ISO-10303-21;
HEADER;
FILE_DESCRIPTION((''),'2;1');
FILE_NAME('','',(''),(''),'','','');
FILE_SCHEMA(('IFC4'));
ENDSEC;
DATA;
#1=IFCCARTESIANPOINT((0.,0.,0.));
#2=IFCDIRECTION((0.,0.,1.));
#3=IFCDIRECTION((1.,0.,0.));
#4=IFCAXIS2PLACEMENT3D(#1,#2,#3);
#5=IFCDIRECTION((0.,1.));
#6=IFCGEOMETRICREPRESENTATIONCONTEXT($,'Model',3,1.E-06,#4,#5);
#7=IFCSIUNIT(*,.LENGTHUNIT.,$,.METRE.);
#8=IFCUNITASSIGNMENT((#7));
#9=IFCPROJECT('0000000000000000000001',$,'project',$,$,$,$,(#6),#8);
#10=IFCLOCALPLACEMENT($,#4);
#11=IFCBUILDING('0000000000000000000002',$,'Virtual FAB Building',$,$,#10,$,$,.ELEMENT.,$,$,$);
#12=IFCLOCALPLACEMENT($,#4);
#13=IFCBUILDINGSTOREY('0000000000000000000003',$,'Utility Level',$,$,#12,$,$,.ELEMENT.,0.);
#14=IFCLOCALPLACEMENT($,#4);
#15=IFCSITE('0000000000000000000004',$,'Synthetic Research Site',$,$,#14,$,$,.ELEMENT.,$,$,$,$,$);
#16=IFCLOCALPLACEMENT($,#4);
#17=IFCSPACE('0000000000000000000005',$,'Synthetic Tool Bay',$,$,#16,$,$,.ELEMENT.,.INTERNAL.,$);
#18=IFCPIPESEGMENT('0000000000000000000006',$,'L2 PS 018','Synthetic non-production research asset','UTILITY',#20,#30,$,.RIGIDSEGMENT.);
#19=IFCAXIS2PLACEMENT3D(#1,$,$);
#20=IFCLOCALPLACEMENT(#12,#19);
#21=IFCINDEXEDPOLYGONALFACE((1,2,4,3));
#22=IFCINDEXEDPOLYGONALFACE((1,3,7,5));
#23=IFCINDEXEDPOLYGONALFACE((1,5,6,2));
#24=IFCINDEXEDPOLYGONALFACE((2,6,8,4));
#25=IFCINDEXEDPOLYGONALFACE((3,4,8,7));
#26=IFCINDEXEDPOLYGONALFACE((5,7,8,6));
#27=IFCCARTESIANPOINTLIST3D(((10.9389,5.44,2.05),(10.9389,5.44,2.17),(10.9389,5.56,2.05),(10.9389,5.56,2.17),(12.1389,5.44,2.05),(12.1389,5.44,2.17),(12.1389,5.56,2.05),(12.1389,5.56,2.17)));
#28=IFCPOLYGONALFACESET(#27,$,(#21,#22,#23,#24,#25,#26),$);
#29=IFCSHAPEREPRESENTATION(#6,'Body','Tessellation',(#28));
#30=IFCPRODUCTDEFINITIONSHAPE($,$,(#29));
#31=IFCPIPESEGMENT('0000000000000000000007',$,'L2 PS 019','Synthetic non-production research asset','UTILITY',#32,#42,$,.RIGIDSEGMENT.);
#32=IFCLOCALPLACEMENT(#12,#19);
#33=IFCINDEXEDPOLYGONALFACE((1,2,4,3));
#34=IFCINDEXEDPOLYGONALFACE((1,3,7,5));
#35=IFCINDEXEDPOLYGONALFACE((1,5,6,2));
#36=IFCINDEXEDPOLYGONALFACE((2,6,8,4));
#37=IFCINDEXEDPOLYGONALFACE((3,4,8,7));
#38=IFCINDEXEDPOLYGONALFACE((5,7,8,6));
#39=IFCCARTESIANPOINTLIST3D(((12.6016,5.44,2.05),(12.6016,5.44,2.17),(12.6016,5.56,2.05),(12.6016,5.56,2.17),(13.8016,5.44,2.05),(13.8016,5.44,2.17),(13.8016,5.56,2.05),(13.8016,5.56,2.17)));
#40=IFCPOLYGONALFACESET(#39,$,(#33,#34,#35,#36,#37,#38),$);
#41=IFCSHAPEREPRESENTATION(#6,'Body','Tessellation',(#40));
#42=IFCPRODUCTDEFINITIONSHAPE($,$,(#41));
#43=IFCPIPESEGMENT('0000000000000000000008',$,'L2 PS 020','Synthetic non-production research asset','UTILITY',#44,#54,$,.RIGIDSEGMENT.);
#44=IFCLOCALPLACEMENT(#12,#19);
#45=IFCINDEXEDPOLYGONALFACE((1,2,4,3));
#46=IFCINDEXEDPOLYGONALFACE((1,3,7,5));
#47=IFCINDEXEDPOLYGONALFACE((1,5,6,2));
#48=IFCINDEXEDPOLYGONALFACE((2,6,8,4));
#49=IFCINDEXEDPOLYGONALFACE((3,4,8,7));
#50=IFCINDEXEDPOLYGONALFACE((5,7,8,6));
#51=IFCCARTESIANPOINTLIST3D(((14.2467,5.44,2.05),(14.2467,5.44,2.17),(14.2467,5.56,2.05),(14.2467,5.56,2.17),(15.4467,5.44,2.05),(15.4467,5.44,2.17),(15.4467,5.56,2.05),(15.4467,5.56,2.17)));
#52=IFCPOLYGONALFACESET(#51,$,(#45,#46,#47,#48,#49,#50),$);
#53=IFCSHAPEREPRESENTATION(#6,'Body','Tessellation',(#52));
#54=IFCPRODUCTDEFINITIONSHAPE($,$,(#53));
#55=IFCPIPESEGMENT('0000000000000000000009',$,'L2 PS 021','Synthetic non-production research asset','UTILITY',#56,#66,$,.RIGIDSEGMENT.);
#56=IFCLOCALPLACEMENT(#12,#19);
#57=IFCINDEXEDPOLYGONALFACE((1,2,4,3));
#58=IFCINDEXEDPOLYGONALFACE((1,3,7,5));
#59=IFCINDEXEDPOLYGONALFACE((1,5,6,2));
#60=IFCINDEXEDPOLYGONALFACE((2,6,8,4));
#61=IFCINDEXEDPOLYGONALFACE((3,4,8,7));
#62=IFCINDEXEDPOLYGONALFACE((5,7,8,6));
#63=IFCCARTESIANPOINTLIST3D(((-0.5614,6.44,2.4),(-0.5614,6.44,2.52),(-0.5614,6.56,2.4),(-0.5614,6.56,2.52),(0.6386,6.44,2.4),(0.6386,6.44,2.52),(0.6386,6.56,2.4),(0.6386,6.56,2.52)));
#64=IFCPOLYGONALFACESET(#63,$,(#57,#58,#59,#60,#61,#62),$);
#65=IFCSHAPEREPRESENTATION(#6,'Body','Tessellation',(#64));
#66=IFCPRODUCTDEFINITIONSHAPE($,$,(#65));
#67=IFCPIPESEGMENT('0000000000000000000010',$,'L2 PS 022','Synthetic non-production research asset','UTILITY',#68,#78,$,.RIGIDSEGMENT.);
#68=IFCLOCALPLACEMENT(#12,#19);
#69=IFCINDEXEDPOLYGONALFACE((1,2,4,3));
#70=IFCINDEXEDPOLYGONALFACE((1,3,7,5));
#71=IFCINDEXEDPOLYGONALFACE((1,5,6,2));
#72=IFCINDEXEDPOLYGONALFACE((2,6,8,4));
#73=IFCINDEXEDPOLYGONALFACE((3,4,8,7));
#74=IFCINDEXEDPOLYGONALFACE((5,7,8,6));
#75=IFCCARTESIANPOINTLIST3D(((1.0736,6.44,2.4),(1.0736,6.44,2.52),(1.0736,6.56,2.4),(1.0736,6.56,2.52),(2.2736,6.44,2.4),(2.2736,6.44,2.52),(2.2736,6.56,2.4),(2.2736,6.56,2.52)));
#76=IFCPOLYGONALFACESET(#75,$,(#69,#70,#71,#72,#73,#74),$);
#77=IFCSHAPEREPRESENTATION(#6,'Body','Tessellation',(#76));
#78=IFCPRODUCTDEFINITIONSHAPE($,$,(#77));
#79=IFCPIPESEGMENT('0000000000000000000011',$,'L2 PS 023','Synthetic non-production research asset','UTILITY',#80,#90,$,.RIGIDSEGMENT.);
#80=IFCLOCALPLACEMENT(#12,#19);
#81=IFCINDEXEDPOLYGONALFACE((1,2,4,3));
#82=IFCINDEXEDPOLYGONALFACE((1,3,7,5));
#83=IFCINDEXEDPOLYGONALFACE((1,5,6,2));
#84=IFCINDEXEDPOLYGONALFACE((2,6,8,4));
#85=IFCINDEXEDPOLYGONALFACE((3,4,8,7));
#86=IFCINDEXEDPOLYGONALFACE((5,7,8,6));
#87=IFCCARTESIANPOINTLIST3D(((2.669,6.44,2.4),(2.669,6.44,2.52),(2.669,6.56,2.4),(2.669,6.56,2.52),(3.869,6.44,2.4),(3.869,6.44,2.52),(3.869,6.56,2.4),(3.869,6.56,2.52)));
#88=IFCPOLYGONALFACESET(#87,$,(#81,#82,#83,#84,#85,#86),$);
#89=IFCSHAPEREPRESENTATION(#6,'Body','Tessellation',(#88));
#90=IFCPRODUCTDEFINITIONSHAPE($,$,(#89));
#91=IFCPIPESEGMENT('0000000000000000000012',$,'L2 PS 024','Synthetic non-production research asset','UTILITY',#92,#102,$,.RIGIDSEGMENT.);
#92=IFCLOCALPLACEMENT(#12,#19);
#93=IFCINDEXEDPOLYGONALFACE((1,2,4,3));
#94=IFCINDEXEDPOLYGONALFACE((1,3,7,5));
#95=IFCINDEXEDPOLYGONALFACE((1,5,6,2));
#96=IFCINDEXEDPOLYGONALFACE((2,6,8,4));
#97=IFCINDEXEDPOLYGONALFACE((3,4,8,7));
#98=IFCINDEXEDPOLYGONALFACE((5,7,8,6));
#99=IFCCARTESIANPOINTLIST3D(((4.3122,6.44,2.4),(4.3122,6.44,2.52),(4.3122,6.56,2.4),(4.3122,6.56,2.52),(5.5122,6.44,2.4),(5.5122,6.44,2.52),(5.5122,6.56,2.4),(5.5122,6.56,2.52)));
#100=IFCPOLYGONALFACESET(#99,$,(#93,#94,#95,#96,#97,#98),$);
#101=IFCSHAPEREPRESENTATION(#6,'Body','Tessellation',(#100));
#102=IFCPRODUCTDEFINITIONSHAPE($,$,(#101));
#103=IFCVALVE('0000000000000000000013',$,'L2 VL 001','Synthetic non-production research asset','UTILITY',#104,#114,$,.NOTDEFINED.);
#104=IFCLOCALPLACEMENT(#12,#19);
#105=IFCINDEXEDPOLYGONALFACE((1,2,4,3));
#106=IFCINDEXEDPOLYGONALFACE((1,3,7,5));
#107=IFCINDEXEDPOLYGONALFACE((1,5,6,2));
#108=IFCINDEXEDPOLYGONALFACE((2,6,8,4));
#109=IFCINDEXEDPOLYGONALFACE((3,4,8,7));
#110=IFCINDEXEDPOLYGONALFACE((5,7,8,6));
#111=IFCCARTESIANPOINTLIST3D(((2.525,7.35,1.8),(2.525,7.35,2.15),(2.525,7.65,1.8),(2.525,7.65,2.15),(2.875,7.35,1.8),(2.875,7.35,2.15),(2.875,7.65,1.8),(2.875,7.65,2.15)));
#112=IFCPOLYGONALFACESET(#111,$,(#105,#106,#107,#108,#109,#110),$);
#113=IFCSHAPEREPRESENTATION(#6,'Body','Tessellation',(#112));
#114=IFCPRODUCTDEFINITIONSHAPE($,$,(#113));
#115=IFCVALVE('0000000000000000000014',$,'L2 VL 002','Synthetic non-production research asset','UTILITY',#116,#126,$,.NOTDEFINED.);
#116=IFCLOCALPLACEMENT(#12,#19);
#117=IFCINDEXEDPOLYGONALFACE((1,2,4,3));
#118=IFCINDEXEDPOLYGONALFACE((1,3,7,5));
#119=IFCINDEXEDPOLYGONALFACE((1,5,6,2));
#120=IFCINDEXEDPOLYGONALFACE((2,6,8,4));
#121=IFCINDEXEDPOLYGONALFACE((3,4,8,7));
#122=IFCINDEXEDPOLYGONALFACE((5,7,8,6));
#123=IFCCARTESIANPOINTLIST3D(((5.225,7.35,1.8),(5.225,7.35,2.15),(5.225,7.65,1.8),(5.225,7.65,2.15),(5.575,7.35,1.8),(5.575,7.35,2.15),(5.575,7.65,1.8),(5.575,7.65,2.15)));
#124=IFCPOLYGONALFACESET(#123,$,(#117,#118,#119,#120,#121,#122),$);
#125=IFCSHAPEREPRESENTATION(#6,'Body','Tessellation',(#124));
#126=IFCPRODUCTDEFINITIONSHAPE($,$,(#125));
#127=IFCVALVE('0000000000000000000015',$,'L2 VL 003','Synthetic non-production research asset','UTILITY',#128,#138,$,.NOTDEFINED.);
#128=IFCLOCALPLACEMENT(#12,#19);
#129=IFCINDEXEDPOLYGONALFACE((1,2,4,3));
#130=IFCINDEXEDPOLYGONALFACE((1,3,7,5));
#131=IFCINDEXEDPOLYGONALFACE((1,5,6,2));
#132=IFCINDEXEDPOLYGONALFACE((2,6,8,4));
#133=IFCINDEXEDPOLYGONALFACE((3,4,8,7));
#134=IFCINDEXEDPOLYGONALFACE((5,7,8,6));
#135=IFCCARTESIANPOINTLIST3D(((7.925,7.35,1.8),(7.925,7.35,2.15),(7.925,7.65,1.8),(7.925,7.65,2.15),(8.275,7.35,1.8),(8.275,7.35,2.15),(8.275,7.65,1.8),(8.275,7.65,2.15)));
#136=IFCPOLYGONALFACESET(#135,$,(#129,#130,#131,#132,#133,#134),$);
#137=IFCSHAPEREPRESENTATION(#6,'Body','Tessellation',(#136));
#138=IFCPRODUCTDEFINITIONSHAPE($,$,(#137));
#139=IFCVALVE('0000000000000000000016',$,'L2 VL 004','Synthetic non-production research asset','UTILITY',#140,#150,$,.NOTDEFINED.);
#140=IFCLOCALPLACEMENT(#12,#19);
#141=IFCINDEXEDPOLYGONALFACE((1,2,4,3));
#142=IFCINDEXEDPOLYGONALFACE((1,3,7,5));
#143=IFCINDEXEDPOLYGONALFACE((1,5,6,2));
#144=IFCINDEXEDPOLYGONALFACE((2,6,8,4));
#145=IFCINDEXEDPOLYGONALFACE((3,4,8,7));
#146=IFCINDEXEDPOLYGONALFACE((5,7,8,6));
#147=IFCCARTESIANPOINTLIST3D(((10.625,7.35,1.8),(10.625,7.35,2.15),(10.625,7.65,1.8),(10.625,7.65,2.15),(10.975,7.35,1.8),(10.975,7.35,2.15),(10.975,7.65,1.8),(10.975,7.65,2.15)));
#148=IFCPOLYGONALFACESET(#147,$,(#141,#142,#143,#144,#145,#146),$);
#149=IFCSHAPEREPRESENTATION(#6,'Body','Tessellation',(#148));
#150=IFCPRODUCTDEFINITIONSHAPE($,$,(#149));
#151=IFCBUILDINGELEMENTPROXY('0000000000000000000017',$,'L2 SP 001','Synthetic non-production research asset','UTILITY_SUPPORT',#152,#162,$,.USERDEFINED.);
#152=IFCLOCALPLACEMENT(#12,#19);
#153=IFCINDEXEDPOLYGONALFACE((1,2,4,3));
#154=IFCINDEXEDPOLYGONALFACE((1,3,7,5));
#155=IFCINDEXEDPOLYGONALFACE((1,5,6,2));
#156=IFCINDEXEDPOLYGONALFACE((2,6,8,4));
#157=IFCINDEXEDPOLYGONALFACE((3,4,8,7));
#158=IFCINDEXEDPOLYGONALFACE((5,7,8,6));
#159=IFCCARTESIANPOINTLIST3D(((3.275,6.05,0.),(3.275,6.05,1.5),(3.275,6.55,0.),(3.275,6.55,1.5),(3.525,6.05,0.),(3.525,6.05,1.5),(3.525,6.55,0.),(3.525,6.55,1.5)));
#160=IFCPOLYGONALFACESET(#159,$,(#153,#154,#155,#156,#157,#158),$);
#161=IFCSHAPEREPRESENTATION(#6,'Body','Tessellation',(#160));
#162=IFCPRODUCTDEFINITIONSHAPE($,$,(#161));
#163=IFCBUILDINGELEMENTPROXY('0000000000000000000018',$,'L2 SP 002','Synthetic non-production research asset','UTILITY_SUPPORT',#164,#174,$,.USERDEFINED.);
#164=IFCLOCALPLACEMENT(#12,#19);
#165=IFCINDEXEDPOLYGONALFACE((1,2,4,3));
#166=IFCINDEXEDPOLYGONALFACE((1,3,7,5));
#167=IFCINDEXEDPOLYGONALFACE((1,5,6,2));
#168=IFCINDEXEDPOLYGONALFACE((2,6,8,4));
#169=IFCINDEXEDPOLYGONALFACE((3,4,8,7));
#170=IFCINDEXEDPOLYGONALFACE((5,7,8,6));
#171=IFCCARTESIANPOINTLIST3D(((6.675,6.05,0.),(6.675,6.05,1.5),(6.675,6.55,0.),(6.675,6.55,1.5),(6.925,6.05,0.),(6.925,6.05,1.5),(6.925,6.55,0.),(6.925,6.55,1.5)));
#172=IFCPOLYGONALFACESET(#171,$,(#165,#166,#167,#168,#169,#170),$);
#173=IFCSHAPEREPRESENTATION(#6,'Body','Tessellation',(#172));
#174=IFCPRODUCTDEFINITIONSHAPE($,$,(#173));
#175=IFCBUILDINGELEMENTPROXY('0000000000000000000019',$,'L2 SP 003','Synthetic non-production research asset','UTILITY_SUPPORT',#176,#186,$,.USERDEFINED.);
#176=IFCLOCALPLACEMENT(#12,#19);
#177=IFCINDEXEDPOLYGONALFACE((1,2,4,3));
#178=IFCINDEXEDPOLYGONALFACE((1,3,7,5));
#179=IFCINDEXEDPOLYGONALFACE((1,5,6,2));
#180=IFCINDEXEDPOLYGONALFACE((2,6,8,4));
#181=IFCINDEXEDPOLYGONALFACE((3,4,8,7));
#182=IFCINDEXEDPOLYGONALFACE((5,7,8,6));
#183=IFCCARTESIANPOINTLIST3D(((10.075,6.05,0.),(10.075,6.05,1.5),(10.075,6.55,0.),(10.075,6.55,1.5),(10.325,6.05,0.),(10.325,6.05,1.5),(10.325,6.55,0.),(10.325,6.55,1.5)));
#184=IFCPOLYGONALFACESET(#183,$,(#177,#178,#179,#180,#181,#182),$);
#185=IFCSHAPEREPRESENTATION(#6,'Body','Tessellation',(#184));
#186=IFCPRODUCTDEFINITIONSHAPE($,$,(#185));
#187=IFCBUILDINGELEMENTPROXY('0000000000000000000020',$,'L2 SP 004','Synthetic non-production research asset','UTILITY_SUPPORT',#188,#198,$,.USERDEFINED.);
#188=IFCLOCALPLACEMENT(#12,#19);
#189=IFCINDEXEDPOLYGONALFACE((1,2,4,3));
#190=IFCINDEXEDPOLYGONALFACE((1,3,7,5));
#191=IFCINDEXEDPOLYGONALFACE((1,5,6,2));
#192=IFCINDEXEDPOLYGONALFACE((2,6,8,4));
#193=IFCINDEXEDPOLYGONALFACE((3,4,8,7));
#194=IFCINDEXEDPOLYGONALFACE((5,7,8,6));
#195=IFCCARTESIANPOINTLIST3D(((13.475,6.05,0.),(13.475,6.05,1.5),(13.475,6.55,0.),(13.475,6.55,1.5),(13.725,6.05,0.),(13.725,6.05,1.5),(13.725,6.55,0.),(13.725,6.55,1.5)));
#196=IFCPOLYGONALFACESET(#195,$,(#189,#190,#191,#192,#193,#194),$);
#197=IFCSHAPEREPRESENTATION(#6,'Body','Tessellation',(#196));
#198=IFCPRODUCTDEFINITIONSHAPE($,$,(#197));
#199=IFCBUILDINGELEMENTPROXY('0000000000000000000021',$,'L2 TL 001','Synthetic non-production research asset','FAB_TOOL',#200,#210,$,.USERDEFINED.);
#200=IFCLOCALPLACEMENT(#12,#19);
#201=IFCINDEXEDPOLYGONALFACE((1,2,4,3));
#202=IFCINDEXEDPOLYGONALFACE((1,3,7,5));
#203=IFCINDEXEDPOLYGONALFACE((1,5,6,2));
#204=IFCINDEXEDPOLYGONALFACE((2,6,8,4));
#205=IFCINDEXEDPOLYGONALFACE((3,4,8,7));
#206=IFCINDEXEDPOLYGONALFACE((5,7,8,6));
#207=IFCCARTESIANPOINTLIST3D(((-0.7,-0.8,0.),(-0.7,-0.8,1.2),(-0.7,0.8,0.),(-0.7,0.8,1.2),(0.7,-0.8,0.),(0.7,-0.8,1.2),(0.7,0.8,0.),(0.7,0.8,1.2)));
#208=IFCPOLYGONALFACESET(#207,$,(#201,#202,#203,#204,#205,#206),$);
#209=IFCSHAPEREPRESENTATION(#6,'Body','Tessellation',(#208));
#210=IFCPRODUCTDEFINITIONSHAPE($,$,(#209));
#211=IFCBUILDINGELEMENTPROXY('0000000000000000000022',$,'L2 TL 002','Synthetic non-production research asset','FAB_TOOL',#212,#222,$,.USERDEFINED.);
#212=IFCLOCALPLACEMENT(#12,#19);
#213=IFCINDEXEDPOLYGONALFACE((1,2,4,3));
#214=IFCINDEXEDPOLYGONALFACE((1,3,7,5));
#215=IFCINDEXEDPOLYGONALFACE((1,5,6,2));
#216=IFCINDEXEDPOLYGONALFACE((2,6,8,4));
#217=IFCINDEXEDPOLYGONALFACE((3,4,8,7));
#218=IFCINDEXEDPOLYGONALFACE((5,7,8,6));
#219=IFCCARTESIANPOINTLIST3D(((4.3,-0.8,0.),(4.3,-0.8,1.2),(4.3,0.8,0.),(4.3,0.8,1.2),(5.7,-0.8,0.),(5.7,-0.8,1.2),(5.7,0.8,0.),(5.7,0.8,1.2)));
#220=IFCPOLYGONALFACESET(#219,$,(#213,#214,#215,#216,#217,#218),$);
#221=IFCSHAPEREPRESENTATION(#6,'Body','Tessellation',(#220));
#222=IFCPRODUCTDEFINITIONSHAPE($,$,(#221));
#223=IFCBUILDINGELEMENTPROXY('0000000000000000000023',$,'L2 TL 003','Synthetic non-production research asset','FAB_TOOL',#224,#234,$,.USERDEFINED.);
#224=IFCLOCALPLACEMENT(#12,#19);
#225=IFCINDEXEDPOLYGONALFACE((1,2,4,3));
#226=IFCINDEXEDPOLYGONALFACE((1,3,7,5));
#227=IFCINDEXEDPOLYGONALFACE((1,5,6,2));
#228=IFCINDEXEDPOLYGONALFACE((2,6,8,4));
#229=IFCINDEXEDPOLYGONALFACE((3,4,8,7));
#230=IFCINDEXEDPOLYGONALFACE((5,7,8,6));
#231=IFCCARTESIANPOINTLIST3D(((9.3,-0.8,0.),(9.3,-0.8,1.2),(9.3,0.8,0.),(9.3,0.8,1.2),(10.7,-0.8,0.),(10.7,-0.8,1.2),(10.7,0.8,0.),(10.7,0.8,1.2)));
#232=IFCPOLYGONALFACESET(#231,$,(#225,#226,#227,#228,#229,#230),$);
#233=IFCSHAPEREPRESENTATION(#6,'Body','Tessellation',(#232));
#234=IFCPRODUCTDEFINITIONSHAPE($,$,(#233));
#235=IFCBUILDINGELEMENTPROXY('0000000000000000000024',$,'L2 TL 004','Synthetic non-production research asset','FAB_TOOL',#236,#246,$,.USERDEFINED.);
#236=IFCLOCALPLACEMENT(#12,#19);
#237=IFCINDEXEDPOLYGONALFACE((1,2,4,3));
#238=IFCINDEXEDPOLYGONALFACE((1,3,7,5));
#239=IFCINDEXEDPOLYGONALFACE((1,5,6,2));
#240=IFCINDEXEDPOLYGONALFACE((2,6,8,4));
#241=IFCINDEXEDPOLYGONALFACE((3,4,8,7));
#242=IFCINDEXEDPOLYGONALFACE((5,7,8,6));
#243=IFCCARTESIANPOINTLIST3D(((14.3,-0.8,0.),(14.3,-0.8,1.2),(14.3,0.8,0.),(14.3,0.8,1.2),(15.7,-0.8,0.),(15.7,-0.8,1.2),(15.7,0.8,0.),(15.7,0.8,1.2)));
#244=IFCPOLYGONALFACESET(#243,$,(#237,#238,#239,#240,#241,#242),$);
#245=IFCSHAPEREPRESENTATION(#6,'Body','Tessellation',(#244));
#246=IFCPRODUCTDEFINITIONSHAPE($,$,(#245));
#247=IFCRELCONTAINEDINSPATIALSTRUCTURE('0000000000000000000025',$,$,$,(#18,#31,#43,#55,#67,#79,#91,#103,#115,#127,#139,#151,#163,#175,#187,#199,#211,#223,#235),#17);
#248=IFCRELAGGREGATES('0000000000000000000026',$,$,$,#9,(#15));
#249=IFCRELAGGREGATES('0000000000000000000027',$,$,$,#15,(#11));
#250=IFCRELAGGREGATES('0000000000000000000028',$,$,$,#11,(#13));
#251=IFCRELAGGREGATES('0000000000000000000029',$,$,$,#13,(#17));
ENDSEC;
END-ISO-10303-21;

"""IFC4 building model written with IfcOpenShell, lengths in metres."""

from ifc_helpers import new_model, si_unit, direction, frame, origin_with_axes, origin_2d_with_axis, place, context, project, spatial, rectangle, extrude, element, save


model = new_model("IFC4")

# Units and contexts
model_context = context("Model", 3, precision=1e-06, world=origin_with_axes(), true_north=direction((0.0, 1.0)))
ifc_project = project(units=[si_unit("LENGTHUNIT", "METRE")], contexts=[model_context])

# Site, building, storey, space
site_placement = place(None, origin_with_axes())
site = spatial("IfcSite", under=ifc_project, at=site_placement, Name="Synthetic Research Site", CompositionType="ELEMENT")
building_placement = place(None, origin_with_axes())
building = spatial("IfcBuilding", under=site, at=building_placement, Name="Virtual FAB Building", CompositionType="ELEMENT")
storey_placement = place(None, origin_with_axes())
storey = spatial("IfcBuildingStorey", under=building, at=storey_placement, Name="Utility Level", CompositionType="ELEMENT", Elevation=0.0)
space_placement = place(None, origin_with_axes())
space = spatial("IfcSpace", under=storey, at=space_placement, Name="Synthetic Tool Bay", CompositionType="ELEMENT", PredefinedType="INTERNAL")

# Pipe segments
for number, where, z_axis, x_axis, name in (
    (1, (11.5389, 5.5, 2.05), (0.0, 0.0, 1.0), (1.0, 0.0, 0.0), "L2 PS 018"),
    (2, (13.2016, 5.5, 2.05), (0.0, 0.0, 1.0), (1.0, 0.0, 0.0), "L2 PS 019"),
    (3, (14.8467, 5.5, 2.05), (0.0, 0.0, 1.0), (1.0, 0.0, 0.0), "L2 PS 020"),
    (4, (0.0386, 6.5, 2.4), (0.0, 0.0, 1.0), (1.0, 0.0, 0.0), "L2 PS 021"),
    (5, (1.6736, 6.5, 2.4), (0.0, 0.0, 1.0), (1.0, 0.0, 0.0), "L2 PS 022"),
    (6, (3.269, 6.5, 2.4), (0.0, 0.0, 1.0), (1.0, 0.0, 0.0), "L2 PS 023"),
    (7, (4.9122, 6.5, 2.4), (0.0, 0.0, 1.0), (1.0, 0.0, 0.0), "L2 PS 024"),
):
    element("IfcPipeSegment", number, at=place(None, frame(where, z_axis=z_axis, x_axis=x_axis)), inside=space, Name=name, Description="Synthetic non-production research asset", ObjectType="UTILITY", PredefinedType="RIGIDSEGMENT", context=model_context, shape_type="SweptSolid", body=[
        extrude(rectangle(XDim=1.2, YDim=0.12, at=origin_2d_with_axis()), origin_with_axes(), (0.0, 0.0, 1.0), 0.12),
    ])

# Valves
for number, where, z_axis, x_axis, name in (
    (8, (2.7, 7.5, 1.8), (0.0, 0.0, 1.0), (1.0, 0.0, 0.0), "L2 VL 001"),
    (9, (5.4, 7.5, 1.8), (0.0, 0.0, 1.0), (1.0, 0.0, 0.0), "L2 VL 002"),
    (10, (8.1, 7.5, 1.8), (0.0, 0.0, 1.0), (1.0, 0.0, 0.0), "L2 VL 003"),
    (11, (10.8, 7.5, 1.8), (0.0, 0.0, 1.0), (1.0, 0.0, 0.0), "L2 VL 004"),
):
    element("IfcValve", number, at=place(None, frame(where, z_axis=z_axis, x_axis=x_axis)), inside=space, Name=name, Description="Synthetic non-production research asset", ObjectType="UTILITY", PredefinedType="NOTDEFINED", context=model_context, shape_type="SweptSolid", body=[
        extrude(rectangle(XDim=0.35, YDim=0.3, at=origin_2d_with_axis()), origin_with_axes(), (0.0, 0.0, 1.0), 0.35),
    ])

# Building element proxies
for number, where, z_axis, x_axis, name in (
    (12, (3.4, 6.3, 0.0), (0.0, 0.0, 1.0), (1.0, 0.0, 0.0), "L2 SP 001"),
    (13, (6.8, 6.3, 0.0), (0.0, 0.0, 1.0), (1.0, 0.0, 0.0), "L2 SP 002"),
    (14, (10.2, 6.3, 0.0), (0.0, 0.0, 1.0), (1.0, 0.0, 0.0), "L2 SP 003"),
    (15, (13.6, 6.3, 0.0), (0.0, 0.0, 1.0), (1.0, 0.0, 0.0), "L2 SP 004"),
):
    element("IfcBuildingElementProxy", number, at=place(None, frame(where, z_axis=z_axis, x_axis=x_axis)), inside=space, Name=name, Description="Synthetic non-production research asset", ObjectType="UTILITY_SUPPORT", PredefinedType="USERDEFINED", context=model_context, shape_type="SweptSolid", body=[
        extrude(rectangle(XDim=0.25, YDim=0.5, at=origin_2d_with_axis()), origin_with_axes(), (0.0, 0.0, 1.0), 1.5),
    ])
for number, where, z_axis, x_axis, name in (
    (16, (0.0, 0.0, 0.0), (0.0, 0.0, 1.0), (1.0, 0.0, 0.0), "L2 TL 001"),
    (17, (5.0, 0.0, 0.0), (0.0, 0.0, 1.0), (1.0, 0.0, 0.0), "L2 TL 002"),
    (18, (10.0, 0.0, 0.0), (0.0, 0.0, 1.0), (1.0, 0.0, 0.0), "L2 TL 003"),
    (19, (15.0, 0.0, 0.0), (0.0, 0.0, 1.0), (1.0, 0.0, 0.0), "L2 TL 004"),
):
    element("IfcBuildingElementProxy", number, at=place(None, frame(where, z_axis=z_axis, x_axis=x_axis)), inside=space, Name=name, Description="Synthetic non-production research asset", ObjectType="FAB_TOOL", PredefinedType="USERDEFINED", context=model_context, shape_type="SweptSolid", body=[
        extrude(rectangle(XDim=1.4, YDim=1.6, at=origin_2d_with_axis()), origin_with_axes(), (0.0, 0.0, 1.0), 1.2),
    ])

save(model, "model.ifc")
